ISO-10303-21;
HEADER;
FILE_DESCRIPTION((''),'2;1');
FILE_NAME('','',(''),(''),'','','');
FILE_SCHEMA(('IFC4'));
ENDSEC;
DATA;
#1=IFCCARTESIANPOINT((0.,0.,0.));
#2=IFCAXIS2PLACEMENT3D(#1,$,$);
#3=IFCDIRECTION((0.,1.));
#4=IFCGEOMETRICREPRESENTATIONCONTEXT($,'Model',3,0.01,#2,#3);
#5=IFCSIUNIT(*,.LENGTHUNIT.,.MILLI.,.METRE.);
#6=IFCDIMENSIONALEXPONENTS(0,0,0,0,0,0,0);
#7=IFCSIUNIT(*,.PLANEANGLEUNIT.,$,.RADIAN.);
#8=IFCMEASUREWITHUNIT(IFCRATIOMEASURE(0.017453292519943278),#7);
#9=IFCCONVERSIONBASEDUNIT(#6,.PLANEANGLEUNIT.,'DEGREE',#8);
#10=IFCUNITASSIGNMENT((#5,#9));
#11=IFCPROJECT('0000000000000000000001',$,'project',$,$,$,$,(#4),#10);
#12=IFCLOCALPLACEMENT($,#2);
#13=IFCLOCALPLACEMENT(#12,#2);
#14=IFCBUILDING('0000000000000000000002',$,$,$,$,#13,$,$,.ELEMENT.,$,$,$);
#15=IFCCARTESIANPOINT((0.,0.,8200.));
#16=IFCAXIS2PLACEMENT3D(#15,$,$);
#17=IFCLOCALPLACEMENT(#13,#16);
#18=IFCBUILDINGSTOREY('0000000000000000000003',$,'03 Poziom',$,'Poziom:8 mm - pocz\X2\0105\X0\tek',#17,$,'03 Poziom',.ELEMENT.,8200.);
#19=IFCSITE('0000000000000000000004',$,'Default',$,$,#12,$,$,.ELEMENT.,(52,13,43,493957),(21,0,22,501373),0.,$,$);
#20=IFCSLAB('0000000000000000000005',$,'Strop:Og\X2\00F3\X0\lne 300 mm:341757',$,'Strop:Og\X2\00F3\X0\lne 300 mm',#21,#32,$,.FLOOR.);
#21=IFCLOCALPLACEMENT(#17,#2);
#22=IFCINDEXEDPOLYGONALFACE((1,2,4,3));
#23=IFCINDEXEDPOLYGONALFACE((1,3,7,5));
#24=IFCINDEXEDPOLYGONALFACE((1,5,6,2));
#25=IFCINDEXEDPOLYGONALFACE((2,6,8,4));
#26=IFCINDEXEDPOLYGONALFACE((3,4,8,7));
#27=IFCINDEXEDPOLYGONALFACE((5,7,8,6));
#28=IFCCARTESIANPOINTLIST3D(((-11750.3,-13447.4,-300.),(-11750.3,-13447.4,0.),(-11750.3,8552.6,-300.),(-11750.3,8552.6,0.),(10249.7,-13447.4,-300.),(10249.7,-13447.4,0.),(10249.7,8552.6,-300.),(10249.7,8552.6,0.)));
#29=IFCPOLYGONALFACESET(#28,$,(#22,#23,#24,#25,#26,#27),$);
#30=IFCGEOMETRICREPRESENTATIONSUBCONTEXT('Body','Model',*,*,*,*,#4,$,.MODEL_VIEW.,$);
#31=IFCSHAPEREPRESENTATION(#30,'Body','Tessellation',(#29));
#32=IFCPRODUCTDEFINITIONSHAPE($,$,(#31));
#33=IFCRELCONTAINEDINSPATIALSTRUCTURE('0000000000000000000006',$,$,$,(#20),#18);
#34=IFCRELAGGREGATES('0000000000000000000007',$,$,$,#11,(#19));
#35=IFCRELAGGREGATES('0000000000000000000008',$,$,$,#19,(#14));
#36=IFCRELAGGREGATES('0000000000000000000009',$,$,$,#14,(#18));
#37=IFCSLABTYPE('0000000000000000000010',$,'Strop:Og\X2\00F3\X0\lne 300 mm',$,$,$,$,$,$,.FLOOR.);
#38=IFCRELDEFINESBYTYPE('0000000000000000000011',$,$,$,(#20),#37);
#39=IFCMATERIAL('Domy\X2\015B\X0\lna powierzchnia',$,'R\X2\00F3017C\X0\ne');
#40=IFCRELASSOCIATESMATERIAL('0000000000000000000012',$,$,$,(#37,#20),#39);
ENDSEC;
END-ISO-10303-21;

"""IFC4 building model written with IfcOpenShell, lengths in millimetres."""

from ifc_helpers import new_model, entity, si_unit, converted_unit, direction, frame, origin, place, context, subcontext, project, spatial, indexed_curve, outline, extrude, material, type_object, element, save


model = new_model("IFC4")

# Units and contexts
model_context = context("Model", 3, precision=0.01, world=origin(), true_north=direction((0.0, 1.0)))
body_context = subcontext(model_context, "Body", "Model", "MODEL_VIEW")
ifc_project = project(units=[si_unit("LENGTHUNIT", "METRE", prefix="MILLI"), converted_unit("PLANEANGLEUNIT", "DEGREE", entity("IfcRatioMeasure", 0.017453292519943278), si_unit("PLANEANGLEUNIT", "RADIAN"), dimensions=[0, 0, 0, 0, 0, 0, 0])], contexts=[model_context])

# Site, building, storey
site_placement = place(None, origin())
site = spatial("IfcSite", under=ifc_project, at=site_placement, Name="Default", CompositionType="ELEMENT", RefLatitude=(52, 13, 43, 493957), RefLongitude=(21, 0, 22, 501373), RefElevation=0.0)
building_placement = place(site_placement, origin())
building = spatial("IfcBuilding", under=site, at=building_placement, CompositionType="ELEMENT")
storey_placement = place(building_placement, frame((0.0, 0.0, 8200.0)))
storey = spatial("IfcBuildingStorey", under=building, at=storey_placement, Name="03 Poziom", ObjectType="Poziom:8 mm - początek", LongName="03 Poziom", CompositionType="ELEMENT", Elevation=8200.0)

# Slab
ifc_material_1 = material(Name="Domyślna powierzchnia", Category="Różne")
slab_type = type_object("IfcSlabType", Name="Strop:Ogólne 300 mm", PredefinedType="FLOOR", material=ifc_material_1)
slab_placement = place(storey_placement, origin())
element("IfcSlab", 1, at=slab_placement, inside=storey, type_object=slab_type, material=ifc_material_1, Name="Strop:Ogólne 300 mm:341757", ObjectType="Strop:Ogólne 300 mm", PredefinedType="FLOOR", context=body_context, shape_type="SweptSolid", body=[
    extrude(outline(indexed_curve([(-11000.0, -11000.0), (11000.0, -11000.0), (11000.0, 11000.0), (-11000.0, 11000.0), (-11000.0, -11000.0)], self_intersect=False)), frame((-750.3, -2447.4, 0.0), z_axis=(0.0, 0.0, -1.0), x_axis=(0.0, 1.0, 0.0)), (0.0, 0.0, 1.0), 300.0),
])

save(model, "model.ifc")
